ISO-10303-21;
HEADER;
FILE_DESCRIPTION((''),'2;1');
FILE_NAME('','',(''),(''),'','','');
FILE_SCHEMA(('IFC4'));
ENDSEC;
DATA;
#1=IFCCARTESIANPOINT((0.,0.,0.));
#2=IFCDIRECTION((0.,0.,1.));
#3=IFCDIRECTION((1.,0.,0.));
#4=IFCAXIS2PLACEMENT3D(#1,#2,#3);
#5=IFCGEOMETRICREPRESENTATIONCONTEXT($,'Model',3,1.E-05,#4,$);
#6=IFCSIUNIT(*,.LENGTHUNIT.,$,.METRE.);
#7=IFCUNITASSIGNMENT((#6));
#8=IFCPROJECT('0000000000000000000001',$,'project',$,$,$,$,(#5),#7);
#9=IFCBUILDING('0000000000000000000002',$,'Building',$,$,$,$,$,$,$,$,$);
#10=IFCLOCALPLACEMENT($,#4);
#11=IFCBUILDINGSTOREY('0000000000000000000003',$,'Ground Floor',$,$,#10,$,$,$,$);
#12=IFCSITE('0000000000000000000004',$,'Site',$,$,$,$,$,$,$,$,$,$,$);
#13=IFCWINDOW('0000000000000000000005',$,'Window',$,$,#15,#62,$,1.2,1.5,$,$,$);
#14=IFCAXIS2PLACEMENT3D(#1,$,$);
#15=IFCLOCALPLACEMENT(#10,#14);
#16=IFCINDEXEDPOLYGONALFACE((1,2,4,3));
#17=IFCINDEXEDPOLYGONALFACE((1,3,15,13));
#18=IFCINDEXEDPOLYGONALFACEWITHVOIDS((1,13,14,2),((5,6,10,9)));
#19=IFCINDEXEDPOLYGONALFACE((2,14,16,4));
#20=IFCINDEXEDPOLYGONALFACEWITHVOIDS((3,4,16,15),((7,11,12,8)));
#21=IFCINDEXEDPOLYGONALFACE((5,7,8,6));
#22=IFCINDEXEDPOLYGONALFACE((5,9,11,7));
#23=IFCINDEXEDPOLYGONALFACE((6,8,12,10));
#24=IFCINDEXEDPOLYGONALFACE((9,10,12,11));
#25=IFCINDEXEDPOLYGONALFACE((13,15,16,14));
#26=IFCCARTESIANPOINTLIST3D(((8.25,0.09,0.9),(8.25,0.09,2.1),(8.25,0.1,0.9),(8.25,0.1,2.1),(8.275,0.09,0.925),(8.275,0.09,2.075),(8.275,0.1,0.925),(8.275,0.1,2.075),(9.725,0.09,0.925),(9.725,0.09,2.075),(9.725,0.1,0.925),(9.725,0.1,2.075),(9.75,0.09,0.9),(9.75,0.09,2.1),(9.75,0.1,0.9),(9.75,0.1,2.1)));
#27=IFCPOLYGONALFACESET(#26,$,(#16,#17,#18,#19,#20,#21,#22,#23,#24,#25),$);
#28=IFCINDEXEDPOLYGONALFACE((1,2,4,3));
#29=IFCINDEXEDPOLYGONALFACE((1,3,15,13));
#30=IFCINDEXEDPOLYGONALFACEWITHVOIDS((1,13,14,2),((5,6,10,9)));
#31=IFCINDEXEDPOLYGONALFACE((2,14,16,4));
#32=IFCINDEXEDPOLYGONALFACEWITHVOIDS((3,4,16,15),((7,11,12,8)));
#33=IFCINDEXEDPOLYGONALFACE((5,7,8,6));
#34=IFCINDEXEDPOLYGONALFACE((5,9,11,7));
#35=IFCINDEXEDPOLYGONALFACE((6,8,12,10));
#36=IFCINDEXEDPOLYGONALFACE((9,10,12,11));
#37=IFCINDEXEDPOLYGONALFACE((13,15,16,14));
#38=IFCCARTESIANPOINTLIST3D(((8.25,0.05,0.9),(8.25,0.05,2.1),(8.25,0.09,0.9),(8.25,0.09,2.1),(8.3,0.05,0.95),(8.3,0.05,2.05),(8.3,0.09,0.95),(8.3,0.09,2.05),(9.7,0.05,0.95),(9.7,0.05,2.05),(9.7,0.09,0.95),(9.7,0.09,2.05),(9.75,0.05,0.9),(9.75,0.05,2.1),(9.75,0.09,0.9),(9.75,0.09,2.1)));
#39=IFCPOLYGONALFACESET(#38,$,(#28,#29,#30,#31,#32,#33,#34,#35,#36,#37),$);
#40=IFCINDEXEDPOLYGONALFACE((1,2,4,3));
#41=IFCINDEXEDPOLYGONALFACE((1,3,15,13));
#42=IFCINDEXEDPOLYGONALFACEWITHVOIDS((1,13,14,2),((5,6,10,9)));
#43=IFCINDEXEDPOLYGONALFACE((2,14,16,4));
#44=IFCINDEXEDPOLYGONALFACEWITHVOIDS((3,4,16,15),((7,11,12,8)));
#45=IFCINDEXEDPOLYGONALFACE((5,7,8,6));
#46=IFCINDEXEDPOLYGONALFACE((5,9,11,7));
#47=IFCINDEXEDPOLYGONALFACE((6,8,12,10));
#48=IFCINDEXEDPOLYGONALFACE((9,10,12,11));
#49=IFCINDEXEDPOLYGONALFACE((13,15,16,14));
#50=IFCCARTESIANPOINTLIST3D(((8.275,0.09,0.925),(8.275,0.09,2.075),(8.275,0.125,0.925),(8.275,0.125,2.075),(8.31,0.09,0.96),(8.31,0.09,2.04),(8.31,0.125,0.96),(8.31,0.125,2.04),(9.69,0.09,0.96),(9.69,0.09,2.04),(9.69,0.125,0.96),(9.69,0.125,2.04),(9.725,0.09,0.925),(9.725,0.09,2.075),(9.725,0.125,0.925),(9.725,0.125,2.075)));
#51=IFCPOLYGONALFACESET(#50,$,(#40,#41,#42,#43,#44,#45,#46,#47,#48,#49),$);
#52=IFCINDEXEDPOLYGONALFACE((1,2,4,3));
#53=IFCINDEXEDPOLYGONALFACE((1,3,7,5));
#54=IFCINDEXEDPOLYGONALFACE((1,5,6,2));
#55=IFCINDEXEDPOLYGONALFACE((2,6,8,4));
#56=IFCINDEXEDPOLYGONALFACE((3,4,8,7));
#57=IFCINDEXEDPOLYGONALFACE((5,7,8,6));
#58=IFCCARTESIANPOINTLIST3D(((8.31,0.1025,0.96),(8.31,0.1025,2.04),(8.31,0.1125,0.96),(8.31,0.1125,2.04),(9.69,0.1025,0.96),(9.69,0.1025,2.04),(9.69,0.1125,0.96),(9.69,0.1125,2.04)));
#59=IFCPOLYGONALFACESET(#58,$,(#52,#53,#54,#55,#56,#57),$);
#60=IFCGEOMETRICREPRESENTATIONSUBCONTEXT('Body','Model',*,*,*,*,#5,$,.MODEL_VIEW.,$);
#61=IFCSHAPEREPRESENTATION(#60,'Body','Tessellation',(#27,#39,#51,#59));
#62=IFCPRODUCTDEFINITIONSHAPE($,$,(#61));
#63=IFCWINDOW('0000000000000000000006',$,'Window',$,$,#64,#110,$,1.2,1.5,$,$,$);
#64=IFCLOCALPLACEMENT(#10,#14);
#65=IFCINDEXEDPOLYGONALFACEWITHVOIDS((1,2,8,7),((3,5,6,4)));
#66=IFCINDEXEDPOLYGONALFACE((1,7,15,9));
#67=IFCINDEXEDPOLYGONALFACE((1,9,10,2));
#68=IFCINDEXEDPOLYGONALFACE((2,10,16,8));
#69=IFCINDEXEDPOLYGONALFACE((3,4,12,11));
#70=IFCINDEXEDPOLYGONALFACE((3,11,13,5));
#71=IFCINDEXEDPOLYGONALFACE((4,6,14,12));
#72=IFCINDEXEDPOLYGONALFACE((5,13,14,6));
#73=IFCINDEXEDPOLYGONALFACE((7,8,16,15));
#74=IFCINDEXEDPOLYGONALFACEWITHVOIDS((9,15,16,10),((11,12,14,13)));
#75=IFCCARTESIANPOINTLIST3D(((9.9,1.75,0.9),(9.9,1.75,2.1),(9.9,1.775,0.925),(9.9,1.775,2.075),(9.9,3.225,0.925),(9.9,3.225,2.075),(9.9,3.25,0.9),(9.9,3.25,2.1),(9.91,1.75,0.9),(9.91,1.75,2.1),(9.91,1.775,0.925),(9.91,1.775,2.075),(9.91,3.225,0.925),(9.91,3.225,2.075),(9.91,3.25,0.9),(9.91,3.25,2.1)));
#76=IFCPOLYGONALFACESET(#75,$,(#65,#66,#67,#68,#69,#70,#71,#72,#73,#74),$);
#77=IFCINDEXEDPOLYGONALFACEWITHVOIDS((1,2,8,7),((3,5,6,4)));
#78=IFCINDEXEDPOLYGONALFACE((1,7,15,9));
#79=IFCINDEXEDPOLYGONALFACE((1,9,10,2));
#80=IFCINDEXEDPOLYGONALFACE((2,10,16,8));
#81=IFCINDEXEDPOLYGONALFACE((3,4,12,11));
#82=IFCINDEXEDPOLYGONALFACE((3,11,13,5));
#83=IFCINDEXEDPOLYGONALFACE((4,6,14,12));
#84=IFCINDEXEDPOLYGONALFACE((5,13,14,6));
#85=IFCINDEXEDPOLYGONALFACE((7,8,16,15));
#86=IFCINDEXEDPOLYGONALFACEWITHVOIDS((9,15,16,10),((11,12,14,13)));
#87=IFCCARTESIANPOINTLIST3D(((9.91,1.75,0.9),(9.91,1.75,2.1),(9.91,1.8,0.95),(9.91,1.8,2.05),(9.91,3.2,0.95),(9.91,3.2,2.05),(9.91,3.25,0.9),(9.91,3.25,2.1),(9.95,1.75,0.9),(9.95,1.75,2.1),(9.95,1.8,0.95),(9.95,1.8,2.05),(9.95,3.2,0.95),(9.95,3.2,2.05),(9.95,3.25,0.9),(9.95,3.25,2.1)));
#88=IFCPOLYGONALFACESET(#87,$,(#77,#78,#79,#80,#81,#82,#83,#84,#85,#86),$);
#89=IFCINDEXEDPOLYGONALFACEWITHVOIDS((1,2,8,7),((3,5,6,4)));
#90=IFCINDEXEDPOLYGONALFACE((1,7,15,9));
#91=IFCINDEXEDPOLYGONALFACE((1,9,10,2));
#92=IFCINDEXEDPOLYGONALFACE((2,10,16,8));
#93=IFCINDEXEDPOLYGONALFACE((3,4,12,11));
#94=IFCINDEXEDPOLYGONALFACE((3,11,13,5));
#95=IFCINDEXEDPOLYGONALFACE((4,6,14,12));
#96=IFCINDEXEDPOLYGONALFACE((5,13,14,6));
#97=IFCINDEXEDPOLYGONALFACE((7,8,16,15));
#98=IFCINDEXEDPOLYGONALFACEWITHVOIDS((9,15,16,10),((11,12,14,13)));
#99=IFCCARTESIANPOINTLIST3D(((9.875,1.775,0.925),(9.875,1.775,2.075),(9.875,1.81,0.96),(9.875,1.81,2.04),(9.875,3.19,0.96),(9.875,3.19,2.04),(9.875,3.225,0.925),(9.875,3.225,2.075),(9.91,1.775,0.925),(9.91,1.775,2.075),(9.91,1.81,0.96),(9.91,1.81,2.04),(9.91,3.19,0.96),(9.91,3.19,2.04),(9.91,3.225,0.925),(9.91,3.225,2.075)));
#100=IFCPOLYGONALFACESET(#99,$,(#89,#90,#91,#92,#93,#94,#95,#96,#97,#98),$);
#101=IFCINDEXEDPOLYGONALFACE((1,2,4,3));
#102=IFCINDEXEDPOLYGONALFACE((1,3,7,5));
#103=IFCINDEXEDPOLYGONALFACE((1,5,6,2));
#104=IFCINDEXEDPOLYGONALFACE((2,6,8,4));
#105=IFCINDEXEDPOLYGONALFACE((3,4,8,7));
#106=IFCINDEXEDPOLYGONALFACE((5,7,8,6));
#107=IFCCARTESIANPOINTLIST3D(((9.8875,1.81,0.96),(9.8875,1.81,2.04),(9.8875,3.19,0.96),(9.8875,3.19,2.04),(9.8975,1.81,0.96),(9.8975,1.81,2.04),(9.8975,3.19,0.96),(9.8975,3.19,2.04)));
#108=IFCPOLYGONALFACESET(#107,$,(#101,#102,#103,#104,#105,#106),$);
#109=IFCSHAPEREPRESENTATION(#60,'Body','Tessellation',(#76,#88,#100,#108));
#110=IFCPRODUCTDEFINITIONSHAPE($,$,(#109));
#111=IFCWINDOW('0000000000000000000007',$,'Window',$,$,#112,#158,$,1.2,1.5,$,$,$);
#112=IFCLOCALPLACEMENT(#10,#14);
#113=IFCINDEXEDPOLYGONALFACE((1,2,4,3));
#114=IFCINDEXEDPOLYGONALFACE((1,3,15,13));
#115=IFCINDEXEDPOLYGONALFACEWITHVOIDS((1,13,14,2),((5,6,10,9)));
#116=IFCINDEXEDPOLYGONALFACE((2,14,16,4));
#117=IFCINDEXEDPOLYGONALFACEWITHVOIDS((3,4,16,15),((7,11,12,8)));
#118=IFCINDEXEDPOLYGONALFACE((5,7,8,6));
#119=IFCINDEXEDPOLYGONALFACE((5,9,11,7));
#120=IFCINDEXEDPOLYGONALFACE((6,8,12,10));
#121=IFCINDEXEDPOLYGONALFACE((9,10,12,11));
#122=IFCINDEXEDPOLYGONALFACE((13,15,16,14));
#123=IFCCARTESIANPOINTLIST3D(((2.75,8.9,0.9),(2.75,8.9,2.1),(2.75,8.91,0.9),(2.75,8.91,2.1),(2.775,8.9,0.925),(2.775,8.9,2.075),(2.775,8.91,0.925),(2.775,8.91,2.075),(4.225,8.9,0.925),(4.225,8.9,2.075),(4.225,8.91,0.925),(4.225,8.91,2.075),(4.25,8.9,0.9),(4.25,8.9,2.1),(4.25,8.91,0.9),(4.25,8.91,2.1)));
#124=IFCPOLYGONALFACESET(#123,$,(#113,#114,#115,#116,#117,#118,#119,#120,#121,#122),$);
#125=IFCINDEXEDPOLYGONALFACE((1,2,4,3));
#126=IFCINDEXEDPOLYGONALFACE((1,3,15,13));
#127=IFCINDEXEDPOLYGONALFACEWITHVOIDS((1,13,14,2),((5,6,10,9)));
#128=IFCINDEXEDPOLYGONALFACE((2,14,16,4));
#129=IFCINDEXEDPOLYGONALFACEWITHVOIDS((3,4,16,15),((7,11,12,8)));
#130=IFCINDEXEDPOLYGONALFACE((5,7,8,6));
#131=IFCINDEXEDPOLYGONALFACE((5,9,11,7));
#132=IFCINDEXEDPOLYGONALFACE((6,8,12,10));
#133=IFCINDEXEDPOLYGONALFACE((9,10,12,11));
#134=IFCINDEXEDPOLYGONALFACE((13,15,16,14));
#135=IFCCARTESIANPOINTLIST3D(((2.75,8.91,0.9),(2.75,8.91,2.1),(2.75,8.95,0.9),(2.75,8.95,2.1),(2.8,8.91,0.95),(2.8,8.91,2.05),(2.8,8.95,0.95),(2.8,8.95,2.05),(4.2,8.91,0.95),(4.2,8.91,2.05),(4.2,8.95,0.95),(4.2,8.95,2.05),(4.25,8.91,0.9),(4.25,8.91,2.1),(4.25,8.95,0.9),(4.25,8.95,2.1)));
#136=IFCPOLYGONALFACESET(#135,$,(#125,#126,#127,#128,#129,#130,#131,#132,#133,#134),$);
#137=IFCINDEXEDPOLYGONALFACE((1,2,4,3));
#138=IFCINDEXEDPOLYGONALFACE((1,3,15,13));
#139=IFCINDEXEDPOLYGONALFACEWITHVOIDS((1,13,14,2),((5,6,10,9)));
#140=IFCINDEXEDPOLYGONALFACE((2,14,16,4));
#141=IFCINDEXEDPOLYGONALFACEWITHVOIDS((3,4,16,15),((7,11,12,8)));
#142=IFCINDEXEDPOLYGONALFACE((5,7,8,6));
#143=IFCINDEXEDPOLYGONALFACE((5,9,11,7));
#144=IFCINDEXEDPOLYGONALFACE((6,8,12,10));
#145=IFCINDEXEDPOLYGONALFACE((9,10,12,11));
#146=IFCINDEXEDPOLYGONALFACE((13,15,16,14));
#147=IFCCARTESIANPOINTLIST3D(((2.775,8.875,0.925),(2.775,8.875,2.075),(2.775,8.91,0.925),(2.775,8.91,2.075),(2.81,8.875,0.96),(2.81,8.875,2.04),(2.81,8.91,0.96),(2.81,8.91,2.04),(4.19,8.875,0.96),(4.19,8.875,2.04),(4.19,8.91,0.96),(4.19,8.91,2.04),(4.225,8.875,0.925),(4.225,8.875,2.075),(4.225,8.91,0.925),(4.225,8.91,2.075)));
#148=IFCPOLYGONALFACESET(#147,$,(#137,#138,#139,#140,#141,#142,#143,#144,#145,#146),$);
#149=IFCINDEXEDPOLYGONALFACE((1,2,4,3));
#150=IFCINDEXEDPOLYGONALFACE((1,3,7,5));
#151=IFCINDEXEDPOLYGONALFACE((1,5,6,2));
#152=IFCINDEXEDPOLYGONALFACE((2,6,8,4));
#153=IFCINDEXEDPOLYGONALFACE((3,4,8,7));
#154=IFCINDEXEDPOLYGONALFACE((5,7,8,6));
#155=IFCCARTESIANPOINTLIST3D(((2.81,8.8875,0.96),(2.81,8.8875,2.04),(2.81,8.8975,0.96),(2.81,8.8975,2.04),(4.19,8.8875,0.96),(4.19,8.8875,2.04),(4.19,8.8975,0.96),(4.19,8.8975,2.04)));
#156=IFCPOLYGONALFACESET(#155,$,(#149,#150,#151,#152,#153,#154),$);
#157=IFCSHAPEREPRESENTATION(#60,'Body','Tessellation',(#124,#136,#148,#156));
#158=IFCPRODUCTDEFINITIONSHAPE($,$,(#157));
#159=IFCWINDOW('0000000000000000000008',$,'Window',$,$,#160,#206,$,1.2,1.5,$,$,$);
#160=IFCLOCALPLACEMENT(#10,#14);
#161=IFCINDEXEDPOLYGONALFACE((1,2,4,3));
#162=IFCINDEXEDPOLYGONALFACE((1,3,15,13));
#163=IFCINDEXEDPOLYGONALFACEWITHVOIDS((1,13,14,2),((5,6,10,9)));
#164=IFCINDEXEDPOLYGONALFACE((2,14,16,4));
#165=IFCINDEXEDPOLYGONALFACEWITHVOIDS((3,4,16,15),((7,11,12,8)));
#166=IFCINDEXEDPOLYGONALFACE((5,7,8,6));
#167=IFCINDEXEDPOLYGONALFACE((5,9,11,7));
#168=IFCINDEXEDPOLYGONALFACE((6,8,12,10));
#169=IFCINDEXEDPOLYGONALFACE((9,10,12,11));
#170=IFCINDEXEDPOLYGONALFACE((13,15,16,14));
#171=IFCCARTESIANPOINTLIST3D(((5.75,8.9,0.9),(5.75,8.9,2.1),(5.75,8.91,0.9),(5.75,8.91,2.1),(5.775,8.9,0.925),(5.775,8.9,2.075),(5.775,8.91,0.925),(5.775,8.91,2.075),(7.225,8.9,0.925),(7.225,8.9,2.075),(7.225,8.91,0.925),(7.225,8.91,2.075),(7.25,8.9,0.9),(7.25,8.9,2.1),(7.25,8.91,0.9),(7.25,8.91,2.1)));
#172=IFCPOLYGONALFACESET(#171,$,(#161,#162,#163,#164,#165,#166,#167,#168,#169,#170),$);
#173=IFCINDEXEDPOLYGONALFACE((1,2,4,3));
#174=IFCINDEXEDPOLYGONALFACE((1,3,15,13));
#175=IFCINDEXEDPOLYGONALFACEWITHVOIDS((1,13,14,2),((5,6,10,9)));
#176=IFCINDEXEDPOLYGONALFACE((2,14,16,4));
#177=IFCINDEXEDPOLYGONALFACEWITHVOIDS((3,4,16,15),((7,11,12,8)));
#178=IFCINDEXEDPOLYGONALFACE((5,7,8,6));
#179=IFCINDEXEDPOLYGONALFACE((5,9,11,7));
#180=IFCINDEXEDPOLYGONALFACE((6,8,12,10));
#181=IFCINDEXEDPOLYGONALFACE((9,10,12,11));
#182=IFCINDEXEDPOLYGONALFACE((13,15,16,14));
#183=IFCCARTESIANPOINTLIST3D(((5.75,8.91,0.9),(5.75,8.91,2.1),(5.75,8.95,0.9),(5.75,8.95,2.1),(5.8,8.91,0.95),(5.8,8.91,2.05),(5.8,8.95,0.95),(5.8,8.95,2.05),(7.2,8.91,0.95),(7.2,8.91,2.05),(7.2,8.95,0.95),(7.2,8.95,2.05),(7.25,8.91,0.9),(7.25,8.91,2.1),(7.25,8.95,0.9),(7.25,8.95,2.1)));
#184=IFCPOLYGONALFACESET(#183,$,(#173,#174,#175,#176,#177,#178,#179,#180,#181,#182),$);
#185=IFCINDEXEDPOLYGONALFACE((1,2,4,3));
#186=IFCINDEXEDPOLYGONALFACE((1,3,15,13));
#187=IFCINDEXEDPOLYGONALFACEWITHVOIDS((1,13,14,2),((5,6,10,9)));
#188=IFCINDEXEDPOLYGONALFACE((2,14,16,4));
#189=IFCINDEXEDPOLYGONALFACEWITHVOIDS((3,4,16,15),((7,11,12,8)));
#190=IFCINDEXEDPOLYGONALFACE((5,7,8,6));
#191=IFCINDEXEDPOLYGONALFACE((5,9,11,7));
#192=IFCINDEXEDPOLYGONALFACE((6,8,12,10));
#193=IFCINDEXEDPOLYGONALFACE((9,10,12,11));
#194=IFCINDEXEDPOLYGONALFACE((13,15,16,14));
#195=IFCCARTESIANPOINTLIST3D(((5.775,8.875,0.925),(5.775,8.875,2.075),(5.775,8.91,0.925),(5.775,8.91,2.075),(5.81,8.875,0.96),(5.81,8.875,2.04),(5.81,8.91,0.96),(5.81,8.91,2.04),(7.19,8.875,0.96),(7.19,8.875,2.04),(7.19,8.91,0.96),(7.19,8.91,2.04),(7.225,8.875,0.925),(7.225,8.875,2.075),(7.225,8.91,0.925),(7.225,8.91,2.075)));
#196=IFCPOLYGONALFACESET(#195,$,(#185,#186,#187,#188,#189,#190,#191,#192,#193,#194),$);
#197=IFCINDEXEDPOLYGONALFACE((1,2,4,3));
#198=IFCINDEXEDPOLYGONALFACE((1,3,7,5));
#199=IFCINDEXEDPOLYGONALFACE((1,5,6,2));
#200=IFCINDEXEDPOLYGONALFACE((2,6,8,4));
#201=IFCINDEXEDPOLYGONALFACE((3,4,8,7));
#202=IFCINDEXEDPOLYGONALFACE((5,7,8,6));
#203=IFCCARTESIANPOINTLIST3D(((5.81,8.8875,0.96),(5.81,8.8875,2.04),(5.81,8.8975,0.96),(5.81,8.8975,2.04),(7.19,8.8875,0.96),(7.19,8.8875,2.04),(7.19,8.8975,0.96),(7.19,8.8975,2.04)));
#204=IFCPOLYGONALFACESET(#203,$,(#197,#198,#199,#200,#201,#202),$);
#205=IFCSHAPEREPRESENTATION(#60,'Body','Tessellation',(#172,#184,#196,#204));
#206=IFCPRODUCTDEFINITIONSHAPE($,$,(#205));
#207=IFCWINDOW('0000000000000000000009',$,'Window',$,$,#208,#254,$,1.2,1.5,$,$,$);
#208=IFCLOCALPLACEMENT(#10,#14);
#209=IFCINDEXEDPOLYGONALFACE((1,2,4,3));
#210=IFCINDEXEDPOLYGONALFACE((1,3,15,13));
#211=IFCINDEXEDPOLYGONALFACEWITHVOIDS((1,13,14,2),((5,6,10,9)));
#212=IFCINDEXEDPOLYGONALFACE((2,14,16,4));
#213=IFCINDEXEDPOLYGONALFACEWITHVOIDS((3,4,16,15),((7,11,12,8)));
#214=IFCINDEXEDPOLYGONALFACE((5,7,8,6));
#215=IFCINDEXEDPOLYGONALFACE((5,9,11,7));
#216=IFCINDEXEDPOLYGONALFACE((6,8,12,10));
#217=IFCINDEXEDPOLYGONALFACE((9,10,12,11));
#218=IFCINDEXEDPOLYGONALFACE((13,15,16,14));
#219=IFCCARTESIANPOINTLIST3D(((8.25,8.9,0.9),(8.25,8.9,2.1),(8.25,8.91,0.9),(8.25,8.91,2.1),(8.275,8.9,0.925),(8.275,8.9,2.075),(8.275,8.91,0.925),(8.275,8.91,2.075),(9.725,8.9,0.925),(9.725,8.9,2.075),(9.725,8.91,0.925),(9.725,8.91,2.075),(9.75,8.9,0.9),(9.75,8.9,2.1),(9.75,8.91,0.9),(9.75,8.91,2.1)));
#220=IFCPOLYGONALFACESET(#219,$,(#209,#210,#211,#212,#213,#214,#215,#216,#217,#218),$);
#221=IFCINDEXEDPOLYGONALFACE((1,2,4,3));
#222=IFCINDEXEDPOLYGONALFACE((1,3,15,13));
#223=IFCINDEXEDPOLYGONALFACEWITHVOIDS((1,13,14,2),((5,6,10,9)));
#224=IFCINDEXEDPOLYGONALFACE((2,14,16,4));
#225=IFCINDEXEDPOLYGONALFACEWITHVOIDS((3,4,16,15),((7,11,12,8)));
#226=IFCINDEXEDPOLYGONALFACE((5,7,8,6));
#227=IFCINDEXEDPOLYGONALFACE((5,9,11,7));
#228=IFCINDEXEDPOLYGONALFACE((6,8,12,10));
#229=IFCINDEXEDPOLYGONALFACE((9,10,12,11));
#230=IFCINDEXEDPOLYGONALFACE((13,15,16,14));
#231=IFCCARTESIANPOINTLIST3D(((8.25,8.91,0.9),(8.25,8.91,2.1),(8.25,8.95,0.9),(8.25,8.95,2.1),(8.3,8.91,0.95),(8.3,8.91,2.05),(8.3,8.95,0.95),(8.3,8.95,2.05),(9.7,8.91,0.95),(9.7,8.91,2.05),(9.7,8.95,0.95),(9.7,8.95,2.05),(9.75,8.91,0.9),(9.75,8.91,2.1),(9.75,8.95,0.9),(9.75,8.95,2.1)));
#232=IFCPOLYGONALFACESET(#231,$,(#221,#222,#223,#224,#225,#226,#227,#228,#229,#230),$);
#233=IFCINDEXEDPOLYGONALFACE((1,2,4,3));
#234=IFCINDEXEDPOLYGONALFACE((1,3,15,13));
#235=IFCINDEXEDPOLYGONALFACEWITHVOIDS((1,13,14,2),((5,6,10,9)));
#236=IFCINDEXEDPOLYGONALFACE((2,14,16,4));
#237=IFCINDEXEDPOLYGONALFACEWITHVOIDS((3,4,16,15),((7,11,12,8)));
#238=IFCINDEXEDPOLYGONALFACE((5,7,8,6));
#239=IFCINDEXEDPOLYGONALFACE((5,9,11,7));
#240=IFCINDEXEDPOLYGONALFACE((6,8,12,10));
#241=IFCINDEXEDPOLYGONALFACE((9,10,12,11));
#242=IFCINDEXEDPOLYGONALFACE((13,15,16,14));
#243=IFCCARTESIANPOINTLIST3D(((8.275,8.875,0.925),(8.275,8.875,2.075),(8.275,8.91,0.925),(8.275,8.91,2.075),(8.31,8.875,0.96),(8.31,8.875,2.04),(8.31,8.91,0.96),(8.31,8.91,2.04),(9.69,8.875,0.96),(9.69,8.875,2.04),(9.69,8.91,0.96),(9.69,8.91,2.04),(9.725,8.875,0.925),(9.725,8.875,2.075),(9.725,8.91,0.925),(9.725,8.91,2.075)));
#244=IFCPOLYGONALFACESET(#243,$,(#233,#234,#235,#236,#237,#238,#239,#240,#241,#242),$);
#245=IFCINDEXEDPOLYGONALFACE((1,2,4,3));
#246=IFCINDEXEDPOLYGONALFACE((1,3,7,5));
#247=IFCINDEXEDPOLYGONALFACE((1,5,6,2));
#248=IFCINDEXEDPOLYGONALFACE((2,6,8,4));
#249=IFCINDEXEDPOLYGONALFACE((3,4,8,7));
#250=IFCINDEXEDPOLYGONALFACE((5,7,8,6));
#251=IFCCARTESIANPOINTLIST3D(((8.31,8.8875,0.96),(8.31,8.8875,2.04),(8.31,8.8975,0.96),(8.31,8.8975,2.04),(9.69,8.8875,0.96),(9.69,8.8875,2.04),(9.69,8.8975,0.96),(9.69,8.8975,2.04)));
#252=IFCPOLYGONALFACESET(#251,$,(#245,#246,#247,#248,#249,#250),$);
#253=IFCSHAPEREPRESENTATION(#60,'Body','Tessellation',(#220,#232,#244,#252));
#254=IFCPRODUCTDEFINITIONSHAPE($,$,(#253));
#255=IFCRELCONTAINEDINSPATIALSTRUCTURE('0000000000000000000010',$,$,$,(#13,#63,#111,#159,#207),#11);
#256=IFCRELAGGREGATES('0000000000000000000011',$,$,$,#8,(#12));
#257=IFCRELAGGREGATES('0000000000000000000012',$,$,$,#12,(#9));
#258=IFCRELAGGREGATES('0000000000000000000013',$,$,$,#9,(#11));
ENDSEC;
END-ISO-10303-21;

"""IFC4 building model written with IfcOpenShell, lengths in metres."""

from ifc_helpers import new_model, si_unit, frame, origin_with_axes, place, context, subcontext, project, spatial, line, indexed_curve, outline, extrude, element, save


model = new_model("IFC4")

# Units and contexts
model_context = context("Model", 3, precision=1e-05, world=origin_with_axes())
body_context = subcontext(model_context, "Body", "Model", "MODEL_VIEW")
ifc_project = project(units=[si_unit("LENGTHUNIT", "METRE")], contexts=[model_context])

# Site, building, storey
site = spatial("IfcSite", under=ifc_project, Name="Site")
building = spatial("IfcBuilding", under=site, Name="Building")
storey_placement = place(None, origin_with_axes())
storey = spatial("IfcBuildingStorey", under=building, at=storey_placement, Name="Ground Floor")

# Windows
for number, where, z_axis, x_axis, name in (
    (1, (8.25, 0.0, 0.9), (0.0, 0.0, 1.0), (1.0, 0.0, 0.0), "Window"),
    (2, (10.0, 1.75, 0.9), (0.0, 0.0, 1.0), (0.0, 1.0, 0.0), "Window"),
    (3, (4.25, 9.0, 0.9), (0.0, 0.0, 1.0), (-1.0, 0.0, 0.0), "Window"),
    (4, (7.25, 9.0, 0.9), (0.0, 0.0, 1.0), (-1.0, 0.0, 0.0), "Window"),
    (5, (9.75, 9.0, 0.9), (0.0, 0.0, 1.0), (-1.0, 0.0, 0.0), "Window"),
):
    element("IfcWindow", number, at=place(storey_placement, frame(where, z_axis=z_axis, x_axis=x_axis)), inside=storey, Name=name, OverallHeight=1.2, OverallWidth=1.5, context=body_context, shape_type="SweptSolid", body=[
        extrude(outline(indexed_curve([(0.0, 0.0), (1.5, 0.0), (1.5, 1.2), (0.0, 1.2)], segments=[line(1, 2, 3, 4, 1)]), holes=[indexed_curve([(0.025, 0.025), (1.475, 0.025), (1.475, 1.175), (0.025, 1.175)], segments=[line(1, 2, 3, 4, 1)])]), frame((0.0, 0.09, 0.0), z_axis=(0.0, -1.0, 0.0), x_axis=(1.0, 0.0, 0.0)), (0.0, 0.0, -1.0), 0.01),
        extrude(outline(indexed_curve([(0.0, 0.0), (1.5, 0.0), (1.5, 1.2), (0.0, 1.2)], segments=[line(1, 2, 3, 4, 1)]), holes=[indexed_curve([(0.05, 0.05), (1.45, 0.05), (1.45, 1.15), (0.05, 1.15)], segments=[line(1, 2, 3, 4, 1)])]), frame((0.0, 0.05, 0.0), z_axis=(0.0, -1.0, 0.0), x_axis=(1.0, 0.0, 0.0)), (0.0, 0.0, -1.0), 0.04),
        extrude(outline(indexed_curve([(0.0, 0.0), (1.45, 0.0), (1.45, 1.15), (0.0, 1.15)], segments=[line(1, 2, 3, 4, 1)]), holes=[indexed_curve([(0.035, 0.035), (1.415, 0.035), (1.415, 1.115), (0.035, 1.115)], segments=[line(1, 2, 3, 4, 1)])]), frame((0.025, 0.09, 0.025), z_axis=(0.0, -1.0, 0.0), x_axis=(1.0, 0.0, 0.0)), (0.0, 0.0, -1.0), 0.035),
        extrude(outline(indexed_curve([(0.035, 0.035), (1.415, 0.035), (1.415, 1.115), (0.035, 1.115)], segments=[line(1, 2, 3, 4, 1)])), frame((0.025, 0.1025, 0.025), z_axis=(0.0, -1.0, 0.0), x_axis=(1.0, 0.0, 0.0)), (0.0, 0.0, -1.0), 0.01),
    ])

save(model, "model.ifc")
